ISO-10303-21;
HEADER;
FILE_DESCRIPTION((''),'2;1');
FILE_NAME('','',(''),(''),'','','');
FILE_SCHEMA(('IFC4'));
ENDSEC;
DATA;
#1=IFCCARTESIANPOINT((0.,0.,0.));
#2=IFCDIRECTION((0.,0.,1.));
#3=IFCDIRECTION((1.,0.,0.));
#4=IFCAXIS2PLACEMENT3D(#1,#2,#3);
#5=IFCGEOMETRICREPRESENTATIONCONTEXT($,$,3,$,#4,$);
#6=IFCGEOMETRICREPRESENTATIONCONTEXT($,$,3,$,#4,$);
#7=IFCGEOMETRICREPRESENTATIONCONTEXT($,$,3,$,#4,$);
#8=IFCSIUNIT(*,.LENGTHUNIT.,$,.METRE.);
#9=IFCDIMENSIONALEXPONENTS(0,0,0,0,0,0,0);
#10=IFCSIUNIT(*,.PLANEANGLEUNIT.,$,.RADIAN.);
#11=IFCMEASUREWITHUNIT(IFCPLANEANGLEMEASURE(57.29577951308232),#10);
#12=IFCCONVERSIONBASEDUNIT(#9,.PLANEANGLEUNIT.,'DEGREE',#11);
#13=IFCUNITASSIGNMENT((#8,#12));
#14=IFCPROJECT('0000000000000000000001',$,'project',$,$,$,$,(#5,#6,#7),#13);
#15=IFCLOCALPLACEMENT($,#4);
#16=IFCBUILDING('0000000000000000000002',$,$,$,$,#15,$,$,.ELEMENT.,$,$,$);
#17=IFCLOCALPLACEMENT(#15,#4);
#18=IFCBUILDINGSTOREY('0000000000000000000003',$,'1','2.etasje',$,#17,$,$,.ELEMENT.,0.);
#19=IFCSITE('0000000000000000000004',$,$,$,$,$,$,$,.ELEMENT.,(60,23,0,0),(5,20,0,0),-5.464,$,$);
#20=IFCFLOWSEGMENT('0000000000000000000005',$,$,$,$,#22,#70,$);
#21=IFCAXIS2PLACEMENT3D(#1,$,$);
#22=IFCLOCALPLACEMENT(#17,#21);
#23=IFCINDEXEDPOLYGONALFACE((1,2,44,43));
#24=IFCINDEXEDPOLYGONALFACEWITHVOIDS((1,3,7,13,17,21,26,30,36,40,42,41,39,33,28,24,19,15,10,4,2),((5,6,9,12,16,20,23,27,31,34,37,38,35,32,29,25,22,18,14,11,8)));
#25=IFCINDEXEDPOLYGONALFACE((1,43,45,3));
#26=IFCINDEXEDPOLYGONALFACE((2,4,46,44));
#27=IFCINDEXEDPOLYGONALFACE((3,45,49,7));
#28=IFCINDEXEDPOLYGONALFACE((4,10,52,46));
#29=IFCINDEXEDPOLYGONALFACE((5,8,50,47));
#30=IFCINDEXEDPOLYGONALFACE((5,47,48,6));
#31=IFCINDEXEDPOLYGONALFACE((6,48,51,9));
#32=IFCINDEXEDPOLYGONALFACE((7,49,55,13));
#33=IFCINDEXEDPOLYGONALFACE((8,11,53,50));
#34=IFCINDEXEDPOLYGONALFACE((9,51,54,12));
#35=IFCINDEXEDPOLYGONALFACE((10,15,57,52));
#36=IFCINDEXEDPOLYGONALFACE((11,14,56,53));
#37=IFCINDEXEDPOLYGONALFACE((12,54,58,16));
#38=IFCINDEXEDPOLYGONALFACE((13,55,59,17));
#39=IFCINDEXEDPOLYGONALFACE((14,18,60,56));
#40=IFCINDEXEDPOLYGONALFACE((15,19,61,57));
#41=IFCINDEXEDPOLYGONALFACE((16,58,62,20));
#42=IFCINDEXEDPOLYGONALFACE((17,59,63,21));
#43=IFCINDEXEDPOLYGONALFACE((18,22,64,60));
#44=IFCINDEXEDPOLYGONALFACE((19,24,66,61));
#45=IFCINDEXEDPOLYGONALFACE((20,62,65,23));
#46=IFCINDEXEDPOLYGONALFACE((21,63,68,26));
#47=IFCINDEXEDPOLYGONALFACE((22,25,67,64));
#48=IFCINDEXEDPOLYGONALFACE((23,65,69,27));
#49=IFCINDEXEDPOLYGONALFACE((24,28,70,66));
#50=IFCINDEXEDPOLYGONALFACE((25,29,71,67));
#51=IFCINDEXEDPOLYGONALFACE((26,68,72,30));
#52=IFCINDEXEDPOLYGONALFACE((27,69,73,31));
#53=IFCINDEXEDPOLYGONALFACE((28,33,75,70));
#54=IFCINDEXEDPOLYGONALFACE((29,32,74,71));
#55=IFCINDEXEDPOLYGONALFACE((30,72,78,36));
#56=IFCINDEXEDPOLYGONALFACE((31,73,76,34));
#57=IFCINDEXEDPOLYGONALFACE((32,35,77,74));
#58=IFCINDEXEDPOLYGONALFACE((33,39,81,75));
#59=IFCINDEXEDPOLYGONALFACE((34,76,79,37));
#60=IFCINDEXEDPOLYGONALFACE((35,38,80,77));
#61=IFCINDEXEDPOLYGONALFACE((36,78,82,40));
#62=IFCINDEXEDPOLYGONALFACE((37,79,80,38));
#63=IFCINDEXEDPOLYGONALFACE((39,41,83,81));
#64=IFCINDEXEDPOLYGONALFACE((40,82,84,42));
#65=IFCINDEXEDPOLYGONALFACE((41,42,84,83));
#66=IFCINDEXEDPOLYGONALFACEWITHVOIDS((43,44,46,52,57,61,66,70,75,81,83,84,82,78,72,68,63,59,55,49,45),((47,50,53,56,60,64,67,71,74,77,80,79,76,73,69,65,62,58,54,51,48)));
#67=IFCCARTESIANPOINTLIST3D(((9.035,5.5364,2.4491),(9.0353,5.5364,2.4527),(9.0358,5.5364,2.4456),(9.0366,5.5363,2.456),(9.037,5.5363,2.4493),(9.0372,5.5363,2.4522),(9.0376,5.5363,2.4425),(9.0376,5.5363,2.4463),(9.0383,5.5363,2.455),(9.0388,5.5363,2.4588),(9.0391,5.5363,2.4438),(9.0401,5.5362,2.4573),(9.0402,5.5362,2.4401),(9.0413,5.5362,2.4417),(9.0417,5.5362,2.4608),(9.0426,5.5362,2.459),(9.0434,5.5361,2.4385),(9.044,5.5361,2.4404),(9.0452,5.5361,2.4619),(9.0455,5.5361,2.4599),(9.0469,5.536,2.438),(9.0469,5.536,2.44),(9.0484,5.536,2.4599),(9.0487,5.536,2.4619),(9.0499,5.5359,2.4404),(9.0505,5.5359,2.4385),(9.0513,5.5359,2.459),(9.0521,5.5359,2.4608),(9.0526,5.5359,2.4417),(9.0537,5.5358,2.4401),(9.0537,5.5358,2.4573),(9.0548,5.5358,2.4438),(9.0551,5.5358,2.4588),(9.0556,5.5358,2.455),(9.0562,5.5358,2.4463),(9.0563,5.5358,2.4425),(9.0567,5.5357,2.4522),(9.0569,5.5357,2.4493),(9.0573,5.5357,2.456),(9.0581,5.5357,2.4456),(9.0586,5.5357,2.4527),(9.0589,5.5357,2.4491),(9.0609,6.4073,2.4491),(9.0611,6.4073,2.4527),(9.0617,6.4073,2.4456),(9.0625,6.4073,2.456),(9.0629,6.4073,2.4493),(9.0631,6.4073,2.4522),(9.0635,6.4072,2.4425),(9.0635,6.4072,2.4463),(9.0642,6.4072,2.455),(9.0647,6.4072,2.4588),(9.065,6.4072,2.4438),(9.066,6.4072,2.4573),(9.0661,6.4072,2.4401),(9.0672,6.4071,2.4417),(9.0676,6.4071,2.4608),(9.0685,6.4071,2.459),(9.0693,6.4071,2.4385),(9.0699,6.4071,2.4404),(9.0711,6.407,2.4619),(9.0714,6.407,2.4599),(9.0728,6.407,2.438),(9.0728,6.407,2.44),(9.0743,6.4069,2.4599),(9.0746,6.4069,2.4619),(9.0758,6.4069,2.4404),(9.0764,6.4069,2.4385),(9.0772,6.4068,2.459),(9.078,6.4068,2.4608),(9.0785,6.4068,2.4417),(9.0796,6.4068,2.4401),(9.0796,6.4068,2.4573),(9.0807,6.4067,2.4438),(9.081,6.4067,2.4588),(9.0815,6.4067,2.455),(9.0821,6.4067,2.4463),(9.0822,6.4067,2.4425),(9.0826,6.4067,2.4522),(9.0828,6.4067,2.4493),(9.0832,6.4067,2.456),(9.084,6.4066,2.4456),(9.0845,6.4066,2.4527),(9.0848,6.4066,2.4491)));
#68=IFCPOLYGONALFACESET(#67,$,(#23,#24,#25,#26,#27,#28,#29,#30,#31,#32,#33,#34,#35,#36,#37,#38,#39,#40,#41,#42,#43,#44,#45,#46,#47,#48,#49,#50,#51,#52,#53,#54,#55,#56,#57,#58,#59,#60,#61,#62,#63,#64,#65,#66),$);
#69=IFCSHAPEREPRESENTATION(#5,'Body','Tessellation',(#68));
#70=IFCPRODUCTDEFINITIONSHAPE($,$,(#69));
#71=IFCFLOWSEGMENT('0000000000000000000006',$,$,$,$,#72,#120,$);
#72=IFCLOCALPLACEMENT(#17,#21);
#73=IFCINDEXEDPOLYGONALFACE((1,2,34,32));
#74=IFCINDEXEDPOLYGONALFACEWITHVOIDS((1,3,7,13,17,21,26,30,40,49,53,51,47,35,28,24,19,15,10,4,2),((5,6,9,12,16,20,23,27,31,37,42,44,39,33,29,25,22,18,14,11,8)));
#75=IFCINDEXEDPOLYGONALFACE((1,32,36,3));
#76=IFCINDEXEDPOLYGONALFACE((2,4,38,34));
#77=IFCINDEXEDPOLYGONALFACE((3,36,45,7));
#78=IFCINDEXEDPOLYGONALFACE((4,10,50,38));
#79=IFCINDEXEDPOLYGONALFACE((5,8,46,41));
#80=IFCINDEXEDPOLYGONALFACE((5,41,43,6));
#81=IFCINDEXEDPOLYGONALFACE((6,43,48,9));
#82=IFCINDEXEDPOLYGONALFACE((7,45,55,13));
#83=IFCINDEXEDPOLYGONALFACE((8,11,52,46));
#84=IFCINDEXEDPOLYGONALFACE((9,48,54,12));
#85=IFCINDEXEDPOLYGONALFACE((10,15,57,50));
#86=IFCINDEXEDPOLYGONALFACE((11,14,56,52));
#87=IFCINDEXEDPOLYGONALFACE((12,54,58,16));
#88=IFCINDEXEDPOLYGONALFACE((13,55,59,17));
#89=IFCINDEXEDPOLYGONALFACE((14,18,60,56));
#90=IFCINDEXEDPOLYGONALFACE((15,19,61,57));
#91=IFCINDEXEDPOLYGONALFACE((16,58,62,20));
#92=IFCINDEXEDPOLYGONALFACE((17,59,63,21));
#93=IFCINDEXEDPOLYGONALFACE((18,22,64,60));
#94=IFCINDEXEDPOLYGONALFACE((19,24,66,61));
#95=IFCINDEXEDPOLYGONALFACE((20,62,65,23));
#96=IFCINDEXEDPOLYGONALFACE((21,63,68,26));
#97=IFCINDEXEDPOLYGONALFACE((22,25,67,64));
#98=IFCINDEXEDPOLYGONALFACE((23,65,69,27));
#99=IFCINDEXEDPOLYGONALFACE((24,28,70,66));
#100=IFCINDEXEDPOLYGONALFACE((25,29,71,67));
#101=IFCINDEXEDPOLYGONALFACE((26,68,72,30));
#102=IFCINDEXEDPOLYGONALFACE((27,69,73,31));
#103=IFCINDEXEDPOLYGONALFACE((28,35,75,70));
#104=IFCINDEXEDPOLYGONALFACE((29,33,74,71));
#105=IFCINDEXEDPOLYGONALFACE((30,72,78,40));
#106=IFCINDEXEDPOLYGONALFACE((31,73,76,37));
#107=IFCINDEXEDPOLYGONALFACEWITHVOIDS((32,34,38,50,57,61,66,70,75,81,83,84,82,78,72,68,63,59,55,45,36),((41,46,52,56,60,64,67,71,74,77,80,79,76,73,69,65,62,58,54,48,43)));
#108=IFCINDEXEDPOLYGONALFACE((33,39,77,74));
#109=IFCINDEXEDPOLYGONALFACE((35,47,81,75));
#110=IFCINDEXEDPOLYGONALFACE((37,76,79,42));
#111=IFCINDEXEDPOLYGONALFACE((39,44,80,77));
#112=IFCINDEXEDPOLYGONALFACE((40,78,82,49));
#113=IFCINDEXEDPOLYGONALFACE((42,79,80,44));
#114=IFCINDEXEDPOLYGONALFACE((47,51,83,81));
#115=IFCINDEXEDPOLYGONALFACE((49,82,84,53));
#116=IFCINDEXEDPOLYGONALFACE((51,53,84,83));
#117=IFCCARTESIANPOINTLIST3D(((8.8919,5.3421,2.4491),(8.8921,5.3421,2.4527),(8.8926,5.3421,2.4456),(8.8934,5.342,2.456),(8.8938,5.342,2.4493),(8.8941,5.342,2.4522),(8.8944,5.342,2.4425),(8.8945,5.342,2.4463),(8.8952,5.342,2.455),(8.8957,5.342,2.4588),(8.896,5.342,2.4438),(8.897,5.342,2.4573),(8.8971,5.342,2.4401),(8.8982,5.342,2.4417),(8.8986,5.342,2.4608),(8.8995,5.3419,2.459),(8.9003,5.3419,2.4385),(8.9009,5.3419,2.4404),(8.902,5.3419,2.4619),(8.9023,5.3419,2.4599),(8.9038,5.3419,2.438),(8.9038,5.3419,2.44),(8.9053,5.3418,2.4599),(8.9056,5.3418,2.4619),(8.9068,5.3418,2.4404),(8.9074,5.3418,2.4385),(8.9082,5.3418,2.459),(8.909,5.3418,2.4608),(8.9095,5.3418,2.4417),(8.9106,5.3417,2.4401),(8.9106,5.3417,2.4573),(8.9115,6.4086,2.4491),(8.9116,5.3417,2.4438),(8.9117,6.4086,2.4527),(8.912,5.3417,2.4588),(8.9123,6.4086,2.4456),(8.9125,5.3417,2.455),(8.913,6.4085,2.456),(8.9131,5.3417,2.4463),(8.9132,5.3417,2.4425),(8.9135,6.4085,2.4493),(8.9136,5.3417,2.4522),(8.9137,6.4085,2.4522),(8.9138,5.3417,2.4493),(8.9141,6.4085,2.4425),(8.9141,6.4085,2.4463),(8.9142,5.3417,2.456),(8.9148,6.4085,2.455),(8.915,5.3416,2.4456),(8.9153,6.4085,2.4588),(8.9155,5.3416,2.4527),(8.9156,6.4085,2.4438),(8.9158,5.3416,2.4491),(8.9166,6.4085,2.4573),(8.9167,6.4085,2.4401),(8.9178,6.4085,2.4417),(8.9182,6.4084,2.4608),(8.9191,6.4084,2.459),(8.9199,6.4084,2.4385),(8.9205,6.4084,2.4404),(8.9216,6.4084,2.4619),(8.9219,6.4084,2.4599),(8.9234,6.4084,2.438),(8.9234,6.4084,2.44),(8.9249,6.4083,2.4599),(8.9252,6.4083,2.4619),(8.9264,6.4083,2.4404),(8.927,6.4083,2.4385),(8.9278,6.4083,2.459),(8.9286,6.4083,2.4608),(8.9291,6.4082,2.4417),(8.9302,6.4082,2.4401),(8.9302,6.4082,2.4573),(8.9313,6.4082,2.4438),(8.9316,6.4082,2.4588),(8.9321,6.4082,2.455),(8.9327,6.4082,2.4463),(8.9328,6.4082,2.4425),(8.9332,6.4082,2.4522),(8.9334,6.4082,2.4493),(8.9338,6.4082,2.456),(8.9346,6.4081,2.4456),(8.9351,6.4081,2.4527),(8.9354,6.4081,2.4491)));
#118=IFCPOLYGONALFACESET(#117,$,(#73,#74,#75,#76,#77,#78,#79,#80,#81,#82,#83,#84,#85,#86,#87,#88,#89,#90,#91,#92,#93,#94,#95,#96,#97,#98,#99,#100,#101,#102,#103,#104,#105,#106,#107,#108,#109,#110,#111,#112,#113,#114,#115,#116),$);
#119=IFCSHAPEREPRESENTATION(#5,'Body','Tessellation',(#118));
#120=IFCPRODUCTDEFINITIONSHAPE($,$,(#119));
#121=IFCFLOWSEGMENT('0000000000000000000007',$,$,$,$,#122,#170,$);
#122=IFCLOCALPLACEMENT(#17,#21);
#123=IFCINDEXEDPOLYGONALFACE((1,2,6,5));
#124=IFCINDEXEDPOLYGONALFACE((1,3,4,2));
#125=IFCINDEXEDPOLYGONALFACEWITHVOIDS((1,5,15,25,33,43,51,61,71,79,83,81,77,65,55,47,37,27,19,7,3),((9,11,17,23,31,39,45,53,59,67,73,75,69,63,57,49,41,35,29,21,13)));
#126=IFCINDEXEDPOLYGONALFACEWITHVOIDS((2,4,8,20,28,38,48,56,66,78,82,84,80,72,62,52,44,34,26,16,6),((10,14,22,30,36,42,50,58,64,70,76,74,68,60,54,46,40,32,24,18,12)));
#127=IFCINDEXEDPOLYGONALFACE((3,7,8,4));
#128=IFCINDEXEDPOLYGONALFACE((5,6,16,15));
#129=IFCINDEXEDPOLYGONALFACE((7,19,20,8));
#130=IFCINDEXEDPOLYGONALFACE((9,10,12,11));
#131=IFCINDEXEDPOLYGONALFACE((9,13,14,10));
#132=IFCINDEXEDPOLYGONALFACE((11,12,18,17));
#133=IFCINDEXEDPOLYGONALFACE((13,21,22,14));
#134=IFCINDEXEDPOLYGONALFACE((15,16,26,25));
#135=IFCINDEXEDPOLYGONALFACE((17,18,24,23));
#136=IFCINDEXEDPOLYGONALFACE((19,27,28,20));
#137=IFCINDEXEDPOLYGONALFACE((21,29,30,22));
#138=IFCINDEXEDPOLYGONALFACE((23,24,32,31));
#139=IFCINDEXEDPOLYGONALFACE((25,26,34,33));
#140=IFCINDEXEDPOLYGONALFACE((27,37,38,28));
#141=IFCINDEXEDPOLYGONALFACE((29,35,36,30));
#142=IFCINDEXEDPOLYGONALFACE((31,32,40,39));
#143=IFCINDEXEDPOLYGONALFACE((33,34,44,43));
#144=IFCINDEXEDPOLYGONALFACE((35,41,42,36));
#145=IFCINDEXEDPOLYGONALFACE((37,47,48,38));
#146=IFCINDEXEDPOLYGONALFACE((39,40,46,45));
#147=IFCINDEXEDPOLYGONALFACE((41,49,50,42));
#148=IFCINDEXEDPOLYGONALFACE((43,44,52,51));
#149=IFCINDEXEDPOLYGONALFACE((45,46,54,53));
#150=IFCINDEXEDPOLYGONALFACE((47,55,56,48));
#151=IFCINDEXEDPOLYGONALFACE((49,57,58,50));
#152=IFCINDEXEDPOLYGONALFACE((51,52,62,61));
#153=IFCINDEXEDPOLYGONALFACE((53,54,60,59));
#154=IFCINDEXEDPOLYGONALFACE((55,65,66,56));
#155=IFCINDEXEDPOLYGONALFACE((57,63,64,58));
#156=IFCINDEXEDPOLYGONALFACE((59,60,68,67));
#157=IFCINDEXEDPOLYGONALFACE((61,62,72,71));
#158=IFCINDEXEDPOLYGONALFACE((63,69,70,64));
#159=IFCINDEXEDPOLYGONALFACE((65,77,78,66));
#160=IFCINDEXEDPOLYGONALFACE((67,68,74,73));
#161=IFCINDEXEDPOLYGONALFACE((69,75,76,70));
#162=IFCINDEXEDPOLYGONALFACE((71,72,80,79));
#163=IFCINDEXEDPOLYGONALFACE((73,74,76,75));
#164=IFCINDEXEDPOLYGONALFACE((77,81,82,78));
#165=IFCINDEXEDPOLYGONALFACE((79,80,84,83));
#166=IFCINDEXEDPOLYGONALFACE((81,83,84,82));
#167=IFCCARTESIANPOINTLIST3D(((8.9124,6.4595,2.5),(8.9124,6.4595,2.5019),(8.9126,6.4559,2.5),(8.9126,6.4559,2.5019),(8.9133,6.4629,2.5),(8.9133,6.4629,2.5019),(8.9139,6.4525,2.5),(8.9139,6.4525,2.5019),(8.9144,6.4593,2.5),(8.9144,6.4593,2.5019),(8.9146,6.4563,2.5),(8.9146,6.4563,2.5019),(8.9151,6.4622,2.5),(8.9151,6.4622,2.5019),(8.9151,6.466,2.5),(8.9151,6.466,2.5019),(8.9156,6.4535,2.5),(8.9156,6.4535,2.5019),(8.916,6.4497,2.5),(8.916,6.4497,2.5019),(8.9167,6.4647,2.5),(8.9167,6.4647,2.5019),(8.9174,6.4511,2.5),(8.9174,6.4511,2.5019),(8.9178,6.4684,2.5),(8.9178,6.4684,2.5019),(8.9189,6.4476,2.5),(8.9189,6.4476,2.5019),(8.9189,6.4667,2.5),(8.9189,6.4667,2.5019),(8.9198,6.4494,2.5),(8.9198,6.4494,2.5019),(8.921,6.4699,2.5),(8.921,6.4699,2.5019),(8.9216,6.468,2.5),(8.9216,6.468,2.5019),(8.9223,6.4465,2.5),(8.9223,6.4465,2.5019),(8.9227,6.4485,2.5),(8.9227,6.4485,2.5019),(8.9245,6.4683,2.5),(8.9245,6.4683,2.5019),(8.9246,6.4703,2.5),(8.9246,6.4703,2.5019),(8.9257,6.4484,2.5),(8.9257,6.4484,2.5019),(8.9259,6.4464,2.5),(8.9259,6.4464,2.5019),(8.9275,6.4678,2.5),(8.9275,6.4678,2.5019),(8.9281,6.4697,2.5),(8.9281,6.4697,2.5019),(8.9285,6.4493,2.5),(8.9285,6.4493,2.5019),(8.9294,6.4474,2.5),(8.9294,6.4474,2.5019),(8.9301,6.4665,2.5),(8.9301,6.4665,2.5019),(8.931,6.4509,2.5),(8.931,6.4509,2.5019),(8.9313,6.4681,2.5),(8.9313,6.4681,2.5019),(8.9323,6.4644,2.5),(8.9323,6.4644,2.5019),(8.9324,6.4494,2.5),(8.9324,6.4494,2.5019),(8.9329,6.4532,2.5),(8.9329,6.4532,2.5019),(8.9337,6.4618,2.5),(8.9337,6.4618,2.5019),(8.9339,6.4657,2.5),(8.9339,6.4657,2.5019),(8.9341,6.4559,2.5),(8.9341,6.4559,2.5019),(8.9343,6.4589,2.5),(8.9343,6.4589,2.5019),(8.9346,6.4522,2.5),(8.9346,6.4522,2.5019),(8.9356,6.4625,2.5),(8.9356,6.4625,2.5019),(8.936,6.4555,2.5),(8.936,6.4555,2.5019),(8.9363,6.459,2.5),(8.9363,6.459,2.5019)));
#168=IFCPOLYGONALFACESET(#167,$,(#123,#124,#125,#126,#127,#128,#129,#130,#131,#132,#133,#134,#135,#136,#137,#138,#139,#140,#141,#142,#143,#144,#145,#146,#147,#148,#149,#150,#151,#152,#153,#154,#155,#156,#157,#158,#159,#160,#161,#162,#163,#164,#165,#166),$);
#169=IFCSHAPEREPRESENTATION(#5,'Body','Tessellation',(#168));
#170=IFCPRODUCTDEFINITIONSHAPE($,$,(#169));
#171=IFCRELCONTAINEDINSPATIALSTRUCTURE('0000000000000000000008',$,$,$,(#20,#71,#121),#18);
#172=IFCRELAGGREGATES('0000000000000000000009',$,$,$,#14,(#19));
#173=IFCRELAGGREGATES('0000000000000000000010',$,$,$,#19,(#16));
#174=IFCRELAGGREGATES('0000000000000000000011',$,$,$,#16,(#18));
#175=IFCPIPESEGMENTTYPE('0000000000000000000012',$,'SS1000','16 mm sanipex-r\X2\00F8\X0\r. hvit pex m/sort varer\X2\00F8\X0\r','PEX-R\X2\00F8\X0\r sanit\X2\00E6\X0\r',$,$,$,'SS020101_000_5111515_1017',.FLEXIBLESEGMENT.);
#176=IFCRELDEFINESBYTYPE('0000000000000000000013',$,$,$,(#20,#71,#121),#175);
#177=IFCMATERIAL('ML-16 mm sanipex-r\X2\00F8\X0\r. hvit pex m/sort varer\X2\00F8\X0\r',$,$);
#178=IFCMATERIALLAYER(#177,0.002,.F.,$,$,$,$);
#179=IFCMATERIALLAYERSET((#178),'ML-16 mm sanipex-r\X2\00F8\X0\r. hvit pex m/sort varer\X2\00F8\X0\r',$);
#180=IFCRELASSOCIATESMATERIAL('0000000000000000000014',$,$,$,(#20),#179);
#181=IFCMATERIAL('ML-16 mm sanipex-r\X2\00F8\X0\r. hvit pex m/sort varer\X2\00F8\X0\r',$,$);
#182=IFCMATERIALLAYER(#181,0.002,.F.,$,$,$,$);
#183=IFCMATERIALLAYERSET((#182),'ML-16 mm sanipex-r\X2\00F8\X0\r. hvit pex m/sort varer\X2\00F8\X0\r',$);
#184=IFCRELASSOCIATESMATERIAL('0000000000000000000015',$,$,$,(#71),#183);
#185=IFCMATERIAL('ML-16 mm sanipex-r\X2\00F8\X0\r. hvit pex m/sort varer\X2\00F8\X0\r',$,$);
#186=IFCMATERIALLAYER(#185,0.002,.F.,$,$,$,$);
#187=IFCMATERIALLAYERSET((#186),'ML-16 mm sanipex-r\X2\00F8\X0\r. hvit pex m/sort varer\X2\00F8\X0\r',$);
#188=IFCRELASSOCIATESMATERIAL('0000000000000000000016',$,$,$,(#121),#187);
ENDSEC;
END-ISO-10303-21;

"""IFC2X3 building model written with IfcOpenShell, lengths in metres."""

from ifc_helpers import new_model, entity, si_unit, converted_unit, frame, origin_with_axes, origin_2d_with_axis, place, context, project, spatial, hollow_circle, extrude, material, layer, layer_set, layer_usage, type_object, element, save


model = new_model("IFC2X3")

# Units and contexts
context_of_model_1 = context(None, 3, world=origin_with_axes())
context_of_model_2 = context(None, 3, world=origin_with_axes())
context_of_model_3 = context(None, 3, world=origin_with_axes())
ifc_project = project(units=[si_unit("LENGTHUNIT", "METRE"), converted_unit("PLANEANGLEUNIT", "DEGREE", entity("IfcPlaneAngleMeasure", 57.29577951308232), si_unit("PLANEANGLEUNIT", "RADIAN"), dimensions=[0, 0, 0, 0, 0, 0, 0])], contexts=[context_of_model_1, context_of_model_2, context_of_model_3])

# Site, building, storey
site = spatial("IfcSite", under=ifc_project, CompositionType="ELEMENT", RefLatitude=(60, 23, 0, 0), RefLongitude=(5, 20, 0, 0), RefElevation=-5.464)
building_placement = place(None, origin_with_axes())
building = spatial("IfcBuilding", under=site, at=building_placement, CompositionType="ELEMENT")
storey_placement = place(building_placement, origin_with_axes())
storey = spatial("IfcBuildingStorey", under=building, at=storey_placement, Name="1", Description="2.etasje", CompositionType="ELEMENT", Elevation=0.0)

# Flow segments
pipe_segment_type_1 = type_object("IfcPipeSegmentType", Name="SS1000", Description="16 mm sanipex-rør. hvit pex m/sort varerør", ApplicableOccurrence="PEX-Rør sanitær", ElementType="SS020101_000_5111515_1017", PredefinedType="FLEXIBLESEGMENT")
ifc_material_1 = material(Name="ML-16 mm sanipex-rør. hvit pex m/sort varerør")
ifc_layer_1 = layer(ifc_material_1, 0.002, ventilated=False)
ifc_layer_set_1 = layer_set([ifc_layer_1], Name="ML-16 mm sanipex-rør. hvit pex m/sort varerør")
ifc_layer_usage_1 = layer_usage(ifc_layer_set_1, "AXIS2", "POSITIVE", 0.0)
flow_segment_1_placement = place(storey_placement, frame((9.0469, 5.536, 2.45), z_axis=(0.02972, 0.999558, 0.0), x_axis=(0.0, 0.0, -1.0)))
element("IfcFlowSegment", 1, at=flow_segment_1_placement, inside=storey, type_object=pipe_segment_type_1, material=ifc_layer_usage_1, context=context_of_model_1, shape_type="SweptSolid", body=[
    extrude(hollow_circle(Radius=0.012, WallThickness=0.002, at=origin_2d_with_axis()), origin_with_axes(), (0.0, 0.0, 1.0), 0.8713),
])
ifc_material_2 = material(Name="ML-16 mm sanipex-rør. hvit pex m/sort varerør")
ifc_layer_2 = layer(ifc_material_2, 0.002, ventilated=False)
ifc_layer_set_2 = layer_set([ifc_layer_2], Name="ML-16 mm sanipex-rør. hvit pex m/sort varerør")
ifc_layer_usage_2 = layer_usage(ifc_layer_set_2, "AXIS2", "POSITIVE", 0.0)
flow_segment_2_placement = place(storey_placement, frame((8.9038, 5.3419, 2.45), z_axis=(0.01839, 0.999831, 0.0), x_axis=(0.0, 0.0, -1.0)))
element("IfcFlowSegment", 2, at=flow_segment_2_placement, inside=storey, type_object=pipe_segment_type_1, material=ifc_layer_usage_2, context=context_of_model_1, shape_type="SweptSolid", body=[
    extrude(hollow_circle(Radius=0.012, WallThickness=0.002, at=origin_2d_with_axis()), origin_with_axes(), (0.0, 0.0, 1.0), 1.0667),
])
ifc_material_3 = material(Name="ML-16 mm sanipex-rør. hvit pex m/sort varerør")
ifc_layer_3 = layer(ifc_material_3, 0.002, ventilated=False)
ifc_layer_set_3 = layer_set([ifc_layer_3], Name="ML-16 mm sanipex-rør. hvit pex m/sort varerør")
ifc_layer_usage_3 = layer_usage(ifc_layer_set_3, "AXIS2", "POSITIVE", 0.0)
flow_segment_3_placement = place(storey_placement, frame((8.9244, 6.4583, 2.5), z_axis=(0.0, 0.0, 1.0), x_axis=(0.01839, 0.999831, 0.0)))
element("IfcFlowSegment", 3, at=flow_segment_3_placement, inside=storey, type_object=pipe_segment_type_1, material=ifc_layer_usage_3, context=context_of_model_1, shape_type="SweptSolid", body=[
    extrude(hollow_circle(Radius=0.012, WallThickness=0.002, at=origin_2d_with_axis()), origin_with_axes(), (0.0, 0.0, 1.0), 0.0019),
])

save(model, "model.ifc")
